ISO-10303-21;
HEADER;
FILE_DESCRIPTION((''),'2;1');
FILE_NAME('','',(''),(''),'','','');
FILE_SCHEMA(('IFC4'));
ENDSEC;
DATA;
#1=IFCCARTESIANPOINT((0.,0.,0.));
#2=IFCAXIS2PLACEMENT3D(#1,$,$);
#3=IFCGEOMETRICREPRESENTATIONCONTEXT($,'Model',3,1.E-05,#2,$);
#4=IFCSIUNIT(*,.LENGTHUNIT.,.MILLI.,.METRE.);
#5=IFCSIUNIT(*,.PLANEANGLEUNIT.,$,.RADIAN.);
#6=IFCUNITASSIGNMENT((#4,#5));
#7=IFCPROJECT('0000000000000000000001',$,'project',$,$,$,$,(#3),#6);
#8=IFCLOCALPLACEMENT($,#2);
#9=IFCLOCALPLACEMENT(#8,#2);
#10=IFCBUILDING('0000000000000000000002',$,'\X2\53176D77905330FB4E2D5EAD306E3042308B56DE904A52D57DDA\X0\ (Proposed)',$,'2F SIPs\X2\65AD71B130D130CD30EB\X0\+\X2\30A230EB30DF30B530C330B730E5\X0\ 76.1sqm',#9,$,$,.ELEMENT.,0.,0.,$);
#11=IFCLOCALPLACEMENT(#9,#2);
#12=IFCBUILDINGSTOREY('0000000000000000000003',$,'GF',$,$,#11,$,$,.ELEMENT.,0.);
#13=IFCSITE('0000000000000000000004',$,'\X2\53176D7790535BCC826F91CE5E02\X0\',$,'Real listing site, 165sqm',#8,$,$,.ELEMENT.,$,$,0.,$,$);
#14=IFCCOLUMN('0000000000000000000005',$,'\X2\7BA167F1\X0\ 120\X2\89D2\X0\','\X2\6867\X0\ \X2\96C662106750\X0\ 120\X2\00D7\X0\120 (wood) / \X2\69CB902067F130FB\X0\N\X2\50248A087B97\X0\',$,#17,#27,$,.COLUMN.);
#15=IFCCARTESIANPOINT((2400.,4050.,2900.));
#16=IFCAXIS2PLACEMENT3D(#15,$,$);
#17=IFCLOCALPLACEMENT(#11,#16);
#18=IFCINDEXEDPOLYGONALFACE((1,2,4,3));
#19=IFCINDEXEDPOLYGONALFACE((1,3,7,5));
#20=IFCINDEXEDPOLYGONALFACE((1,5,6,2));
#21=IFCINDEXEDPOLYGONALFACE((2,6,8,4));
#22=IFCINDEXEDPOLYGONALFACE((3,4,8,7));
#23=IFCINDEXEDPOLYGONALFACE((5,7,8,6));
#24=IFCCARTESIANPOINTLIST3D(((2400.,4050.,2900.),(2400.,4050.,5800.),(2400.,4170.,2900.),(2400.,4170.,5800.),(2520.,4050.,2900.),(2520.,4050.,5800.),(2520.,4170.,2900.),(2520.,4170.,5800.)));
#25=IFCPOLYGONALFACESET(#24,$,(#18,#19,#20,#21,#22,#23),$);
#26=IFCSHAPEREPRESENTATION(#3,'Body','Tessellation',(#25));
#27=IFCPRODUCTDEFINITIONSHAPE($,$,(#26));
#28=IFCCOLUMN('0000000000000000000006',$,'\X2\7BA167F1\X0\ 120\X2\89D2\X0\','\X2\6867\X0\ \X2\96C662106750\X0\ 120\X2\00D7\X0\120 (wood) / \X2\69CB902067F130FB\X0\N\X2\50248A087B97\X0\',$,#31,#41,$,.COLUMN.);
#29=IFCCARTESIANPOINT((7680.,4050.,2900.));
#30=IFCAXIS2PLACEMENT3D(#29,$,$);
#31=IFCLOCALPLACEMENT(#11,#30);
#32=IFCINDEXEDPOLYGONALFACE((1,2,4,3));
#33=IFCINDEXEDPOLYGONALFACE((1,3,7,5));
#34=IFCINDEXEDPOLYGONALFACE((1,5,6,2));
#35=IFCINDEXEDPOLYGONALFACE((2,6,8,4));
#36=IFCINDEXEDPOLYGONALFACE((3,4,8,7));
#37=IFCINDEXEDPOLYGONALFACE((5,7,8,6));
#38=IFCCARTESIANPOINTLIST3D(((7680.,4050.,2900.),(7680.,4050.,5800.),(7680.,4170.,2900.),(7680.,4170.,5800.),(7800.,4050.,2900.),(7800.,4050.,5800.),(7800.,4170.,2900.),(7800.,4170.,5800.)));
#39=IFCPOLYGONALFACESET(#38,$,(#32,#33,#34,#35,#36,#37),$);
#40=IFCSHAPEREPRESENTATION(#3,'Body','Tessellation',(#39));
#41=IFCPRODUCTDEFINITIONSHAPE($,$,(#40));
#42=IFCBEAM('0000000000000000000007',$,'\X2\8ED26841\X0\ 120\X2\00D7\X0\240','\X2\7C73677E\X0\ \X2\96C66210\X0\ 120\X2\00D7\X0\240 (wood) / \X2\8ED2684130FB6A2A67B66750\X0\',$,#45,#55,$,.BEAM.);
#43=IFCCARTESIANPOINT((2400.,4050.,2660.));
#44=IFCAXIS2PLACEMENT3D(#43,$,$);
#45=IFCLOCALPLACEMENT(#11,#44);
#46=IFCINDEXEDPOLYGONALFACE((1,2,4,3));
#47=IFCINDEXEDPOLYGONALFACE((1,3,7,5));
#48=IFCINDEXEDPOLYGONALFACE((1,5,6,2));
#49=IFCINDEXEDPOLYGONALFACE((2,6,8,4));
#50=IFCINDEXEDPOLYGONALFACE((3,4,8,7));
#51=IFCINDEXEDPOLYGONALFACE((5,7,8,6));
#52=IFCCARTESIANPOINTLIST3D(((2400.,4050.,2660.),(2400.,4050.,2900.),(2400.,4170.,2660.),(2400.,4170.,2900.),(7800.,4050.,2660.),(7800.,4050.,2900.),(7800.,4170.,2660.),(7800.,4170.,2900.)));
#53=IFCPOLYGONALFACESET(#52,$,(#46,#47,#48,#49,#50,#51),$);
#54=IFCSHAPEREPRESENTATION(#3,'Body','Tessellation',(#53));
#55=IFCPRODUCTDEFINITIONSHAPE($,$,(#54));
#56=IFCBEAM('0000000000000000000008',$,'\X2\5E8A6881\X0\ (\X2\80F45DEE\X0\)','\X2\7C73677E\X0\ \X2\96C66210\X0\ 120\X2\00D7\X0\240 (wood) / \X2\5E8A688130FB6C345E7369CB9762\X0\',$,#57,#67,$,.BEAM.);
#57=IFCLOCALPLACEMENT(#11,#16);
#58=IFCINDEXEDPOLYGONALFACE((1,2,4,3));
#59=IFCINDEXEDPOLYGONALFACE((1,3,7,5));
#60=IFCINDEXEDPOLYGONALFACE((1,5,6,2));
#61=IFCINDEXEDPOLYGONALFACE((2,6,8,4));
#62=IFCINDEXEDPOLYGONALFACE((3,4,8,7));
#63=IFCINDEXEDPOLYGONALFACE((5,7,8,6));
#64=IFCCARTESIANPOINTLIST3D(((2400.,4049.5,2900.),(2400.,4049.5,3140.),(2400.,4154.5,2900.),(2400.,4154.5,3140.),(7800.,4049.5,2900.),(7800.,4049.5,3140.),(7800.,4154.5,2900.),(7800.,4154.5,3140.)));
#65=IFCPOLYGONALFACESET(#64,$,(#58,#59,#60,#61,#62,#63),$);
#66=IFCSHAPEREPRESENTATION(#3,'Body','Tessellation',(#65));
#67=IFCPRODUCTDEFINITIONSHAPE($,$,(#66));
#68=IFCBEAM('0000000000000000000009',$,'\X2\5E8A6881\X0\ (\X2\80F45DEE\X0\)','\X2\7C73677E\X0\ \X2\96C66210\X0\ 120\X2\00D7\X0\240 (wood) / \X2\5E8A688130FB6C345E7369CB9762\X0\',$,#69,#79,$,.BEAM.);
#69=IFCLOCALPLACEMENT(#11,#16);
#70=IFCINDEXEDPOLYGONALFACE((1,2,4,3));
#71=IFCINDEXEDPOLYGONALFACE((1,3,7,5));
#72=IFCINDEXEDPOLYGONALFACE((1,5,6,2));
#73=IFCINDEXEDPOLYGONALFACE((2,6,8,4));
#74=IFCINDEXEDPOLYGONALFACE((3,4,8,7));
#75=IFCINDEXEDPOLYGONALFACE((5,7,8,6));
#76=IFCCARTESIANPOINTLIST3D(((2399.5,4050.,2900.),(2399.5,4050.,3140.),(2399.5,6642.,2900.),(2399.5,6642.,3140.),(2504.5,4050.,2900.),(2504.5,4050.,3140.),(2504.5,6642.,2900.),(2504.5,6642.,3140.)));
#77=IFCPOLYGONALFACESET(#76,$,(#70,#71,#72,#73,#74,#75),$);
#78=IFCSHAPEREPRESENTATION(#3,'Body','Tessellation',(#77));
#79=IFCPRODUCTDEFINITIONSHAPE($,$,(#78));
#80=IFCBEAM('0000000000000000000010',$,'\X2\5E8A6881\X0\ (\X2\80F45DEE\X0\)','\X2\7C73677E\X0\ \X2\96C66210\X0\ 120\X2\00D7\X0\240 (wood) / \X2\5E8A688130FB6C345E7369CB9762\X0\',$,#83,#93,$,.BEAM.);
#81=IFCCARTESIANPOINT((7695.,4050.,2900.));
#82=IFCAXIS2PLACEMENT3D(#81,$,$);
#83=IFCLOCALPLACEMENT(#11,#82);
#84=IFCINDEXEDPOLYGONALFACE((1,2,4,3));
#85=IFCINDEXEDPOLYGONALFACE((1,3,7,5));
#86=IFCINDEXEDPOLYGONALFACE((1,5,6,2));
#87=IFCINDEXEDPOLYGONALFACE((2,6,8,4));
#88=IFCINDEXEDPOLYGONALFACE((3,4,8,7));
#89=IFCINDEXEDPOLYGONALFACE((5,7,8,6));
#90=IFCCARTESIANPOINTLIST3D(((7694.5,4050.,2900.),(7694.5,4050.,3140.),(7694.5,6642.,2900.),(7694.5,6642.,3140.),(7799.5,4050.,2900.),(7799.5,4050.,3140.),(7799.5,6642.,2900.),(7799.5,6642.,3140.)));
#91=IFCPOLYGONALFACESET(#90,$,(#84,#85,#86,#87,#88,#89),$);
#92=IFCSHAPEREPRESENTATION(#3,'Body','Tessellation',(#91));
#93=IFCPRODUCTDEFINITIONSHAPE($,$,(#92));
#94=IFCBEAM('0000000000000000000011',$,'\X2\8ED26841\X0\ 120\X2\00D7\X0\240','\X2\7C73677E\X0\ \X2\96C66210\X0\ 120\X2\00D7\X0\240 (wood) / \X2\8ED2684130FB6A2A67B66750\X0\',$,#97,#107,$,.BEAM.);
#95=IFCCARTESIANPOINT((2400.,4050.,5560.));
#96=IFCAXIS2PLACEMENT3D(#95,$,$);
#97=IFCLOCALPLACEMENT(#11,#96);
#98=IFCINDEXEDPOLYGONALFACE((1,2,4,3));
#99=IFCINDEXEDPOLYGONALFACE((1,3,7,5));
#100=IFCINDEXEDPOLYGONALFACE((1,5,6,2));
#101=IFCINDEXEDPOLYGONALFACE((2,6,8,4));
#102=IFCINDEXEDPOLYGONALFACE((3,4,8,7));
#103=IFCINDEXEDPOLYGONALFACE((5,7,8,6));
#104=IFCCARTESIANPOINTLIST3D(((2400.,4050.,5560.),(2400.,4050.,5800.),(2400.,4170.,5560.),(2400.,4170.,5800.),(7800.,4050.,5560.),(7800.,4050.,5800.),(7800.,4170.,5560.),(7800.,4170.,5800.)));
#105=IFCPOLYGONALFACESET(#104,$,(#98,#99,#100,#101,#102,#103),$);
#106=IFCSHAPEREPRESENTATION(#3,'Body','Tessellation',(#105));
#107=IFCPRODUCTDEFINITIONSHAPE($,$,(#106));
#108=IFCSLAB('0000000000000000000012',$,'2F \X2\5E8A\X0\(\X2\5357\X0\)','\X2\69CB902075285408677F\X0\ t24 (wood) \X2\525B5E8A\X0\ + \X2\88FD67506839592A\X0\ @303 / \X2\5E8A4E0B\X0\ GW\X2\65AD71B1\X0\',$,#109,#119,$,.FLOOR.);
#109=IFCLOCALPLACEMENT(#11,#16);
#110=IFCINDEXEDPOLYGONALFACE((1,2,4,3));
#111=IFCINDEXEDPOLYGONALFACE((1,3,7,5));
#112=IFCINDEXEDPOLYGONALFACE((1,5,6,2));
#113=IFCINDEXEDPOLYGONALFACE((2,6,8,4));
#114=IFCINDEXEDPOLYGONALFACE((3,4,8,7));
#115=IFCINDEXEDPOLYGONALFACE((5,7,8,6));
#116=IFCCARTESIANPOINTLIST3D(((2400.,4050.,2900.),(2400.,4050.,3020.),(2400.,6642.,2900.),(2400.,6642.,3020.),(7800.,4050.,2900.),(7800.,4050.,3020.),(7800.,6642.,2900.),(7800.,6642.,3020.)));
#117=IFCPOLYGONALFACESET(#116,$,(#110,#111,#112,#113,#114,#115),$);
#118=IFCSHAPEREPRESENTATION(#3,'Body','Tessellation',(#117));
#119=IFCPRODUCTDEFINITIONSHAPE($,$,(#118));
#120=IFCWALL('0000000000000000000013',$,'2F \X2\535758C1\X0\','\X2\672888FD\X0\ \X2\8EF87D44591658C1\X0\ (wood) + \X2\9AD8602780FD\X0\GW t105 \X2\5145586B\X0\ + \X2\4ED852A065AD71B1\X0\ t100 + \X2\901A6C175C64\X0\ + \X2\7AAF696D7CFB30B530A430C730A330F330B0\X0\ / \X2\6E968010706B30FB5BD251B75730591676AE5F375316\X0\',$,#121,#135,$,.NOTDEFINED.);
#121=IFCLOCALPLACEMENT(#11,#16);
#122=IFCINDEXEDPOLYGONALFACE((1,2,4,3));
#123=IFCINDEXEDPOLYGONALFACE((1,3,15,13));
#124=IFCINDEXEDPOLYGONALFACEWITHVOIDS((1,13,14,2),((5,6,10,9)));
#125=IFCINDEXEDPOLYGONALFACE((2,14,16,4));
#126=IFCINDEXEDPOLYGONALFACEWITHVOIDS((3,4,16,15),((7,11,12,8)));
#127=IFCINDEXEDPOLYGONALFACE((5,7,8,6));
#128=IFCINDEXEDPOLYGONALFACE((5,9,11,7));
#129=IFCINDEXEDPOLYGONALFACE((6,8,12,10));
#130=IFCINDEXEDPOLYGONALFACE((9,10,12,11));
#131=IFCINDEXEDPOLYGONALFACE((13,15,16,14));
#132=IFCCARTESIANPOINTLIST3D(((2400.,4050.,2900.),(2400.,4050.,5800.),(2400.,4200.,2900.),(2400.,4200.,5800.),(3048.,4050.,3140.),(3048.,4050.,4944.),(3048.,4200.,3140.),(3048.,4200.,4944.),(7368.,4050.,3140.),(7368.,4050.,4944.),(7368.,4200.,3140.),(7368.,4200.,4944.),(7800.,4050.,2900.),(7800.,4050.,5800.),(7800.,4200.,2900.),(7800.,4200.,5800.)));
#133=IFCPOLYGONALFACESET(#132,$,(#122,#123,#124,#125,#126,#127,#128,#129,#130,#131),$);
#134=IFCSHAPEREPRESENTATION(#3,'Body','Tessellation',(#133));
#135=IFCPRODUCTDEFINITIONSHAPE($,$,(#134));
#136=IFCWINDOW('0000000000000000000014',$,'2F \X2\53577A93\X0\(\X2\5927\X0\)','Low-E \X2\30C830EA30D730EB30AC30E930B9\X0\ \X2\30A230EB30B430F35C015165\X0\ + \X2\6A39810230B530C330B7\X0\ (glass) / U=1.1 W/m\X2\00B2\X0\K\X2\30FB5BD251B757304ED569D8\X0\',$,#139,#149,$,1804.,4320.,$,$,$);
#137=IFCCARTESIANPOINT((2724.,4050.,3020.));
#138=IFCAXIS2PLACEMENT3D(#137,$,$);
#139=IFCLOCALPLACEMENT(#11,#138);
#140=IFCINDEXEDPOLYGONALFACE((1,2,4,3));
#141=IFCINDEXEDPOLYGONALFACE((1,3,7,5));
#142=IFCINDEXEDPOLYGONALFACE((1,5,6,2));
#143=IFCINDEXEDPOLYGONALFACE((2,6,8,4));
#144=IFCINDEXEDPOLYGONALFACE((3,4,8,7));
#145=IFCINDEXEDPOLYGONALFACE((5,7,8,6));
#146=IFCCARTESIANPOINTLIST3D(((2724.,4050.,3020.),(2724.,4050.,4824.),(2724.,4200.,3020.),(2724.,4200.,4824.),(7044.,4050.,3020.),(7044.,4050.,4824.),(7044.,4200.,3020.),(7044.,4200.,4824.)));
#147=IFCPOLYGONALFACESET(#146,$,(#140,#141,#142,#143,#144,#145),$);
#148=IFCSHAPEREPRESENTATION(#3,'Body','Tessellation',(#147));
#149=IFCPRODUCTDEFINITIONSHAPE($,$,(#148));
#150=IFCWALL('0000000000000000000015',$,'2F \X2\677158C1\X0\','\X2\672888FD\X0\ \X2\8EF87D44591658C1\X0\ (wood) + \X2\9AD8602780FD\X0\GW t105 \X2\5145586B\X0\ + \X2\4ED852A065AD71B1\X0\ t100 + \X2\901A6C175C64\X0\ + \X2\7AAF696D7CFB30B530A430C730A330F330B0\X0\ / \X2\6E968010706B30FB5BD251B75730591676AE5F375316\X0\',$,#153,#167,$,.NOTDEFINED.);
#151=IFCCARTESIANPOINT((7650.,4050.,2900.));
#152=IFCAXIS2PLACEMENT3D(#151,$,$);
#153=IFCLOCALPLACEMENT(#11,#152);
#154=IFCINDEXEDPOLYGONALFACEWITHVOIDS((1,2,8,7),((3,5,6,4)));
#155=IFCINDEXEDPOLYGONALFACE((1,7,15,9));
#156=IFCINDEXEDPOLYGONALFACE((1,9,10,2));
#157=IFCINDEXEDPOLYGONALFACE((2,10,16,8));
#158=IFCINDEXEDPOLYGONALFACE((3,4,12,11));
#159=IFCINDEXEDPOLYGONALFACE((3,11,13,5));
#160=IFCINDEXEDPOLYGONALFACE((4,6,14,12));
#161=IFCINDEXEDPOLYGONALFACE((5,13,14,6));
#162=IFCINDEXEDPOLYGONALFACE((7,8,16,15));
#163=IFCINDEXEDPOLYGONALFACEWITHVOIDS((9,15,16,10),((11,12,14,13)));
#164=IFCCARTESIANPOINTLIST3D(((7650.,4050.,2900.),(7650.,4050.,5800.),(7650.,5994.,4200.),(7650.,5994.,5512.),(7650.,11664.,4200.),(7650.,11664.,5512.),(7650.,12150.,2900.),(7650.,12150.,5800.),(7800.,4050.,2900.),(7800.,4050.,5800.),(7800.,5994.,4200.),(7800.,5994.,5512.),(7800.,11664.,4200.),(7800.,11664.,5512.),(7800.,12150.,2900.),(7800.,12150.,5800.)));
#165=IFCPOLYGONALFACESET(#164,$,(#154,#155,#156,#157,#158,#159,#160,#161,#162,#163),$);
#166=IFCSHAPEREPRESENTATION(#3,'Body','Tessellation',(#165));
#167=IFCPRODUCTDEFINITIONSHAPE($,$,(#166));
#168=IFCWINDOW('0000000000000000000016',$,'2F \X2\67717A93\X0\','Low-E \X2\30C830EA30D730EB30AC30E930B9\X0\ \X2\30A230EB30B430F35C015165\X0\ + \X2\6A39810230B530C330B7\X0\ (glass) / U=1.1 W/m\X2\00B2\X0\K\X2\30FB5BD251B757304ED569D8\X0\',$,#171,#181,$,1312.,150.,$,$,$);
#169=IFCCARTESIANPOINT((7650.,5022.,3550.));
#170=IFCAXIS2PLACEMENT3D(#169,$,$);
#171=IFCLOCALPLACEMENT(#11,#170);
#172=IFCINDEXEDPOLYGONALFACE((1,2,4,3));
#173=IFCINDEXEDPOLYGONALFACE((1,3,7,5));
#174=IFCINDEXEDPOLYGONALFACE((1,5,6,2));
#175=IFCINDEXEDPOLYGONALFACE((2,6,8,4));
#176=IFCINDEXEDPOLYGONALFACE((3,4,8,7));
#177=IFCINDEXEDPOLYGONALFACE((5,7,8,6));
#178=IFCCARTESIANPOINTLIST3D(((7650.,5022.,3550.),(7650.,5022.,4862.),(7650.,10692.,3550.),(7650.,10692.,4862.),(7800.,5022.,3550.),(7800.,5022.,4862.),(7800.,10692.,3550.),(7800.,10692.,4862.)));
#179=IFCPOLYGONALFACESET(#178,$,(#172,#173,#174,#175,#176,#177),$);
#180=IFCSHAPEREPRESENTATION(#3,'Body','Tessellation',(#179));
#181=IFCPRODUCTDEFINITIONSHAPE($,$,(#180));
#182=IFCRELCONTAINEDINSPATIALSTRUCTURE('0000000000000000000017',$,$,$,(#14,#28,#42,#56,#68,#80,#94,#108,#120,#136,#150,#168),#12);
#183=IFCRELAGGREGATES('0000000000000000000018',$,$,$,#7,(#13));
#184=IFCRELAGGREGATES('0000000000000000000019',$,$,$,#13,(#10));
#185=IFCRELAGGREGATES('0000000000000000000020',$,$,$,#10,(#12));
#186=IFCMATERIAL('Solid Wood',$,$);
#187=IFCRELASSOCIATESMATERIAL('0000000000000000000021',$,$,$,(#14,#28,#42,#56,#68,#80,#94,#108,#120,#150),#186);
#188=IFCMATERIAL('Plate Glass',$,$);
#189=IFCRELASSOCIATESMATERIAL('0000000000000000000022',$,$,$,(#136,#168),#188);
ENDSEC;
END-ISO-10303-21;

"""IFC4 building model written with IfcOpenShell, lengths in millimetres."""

from ifc_helpers import new_model, si_unit, frame, frame_2d, origin, place, context, project, spatial, rectangle, extrude, material, element, fill, save


model = new_model("IFC4")

# Units and contexts
model_context = context("Model", 3, precision=1e-05, world=origin())
ifc_project = project(units=[si_unit("LENGTHUNIT", "METRE", prefix="MILLI"), si_unit("PLANEANGLEUNIT", "RADIAN")], contexts=[model_context])

# Site, building, storey
site_placement = place(None, origin())
site = spatial("IfcSite", under=ifc_project, at=site_placement, Name="北海道富良野市", ObjectType="Real listing site, 165sqm", CompositionType="ELEMENT", RefElevation=0.0)
building_placement = place(site_placement, origin())
building = spatial("IfcBuilding", under=site, at=building_placement, Name="北海道・中庭のある回遊動線 (Proposed)", ObjectType="2F SIPs断熱パネル+アルミサッシュ 76.1sqm", CompositionType="ELEMENT", ElevationOfRefHeight=0.0, ElevationOfTerrain=0.0)
storey_placement = place(building_placement, origin())
storey = spatial("IfcBuildingStorey", under=building, at=storey_placement, Name="GF", CompositionType="ELEMENT", Elevation=0.0)

# Columns
ifc_material_1 = material(Name="Solid Wood")
column_1_placement = place(storey_placement, frame((2400.0, 4050.0, 2900.0)))
element("IfcColumn", 1, at=column_1_placement, inside=storey, material=ifc_material_1, Name="管柱 120角", Description="桧 集成材 120×120 (wood) / 構造柱・N値計算", PredefinedType="COLUMN", context=model_context, shape_type="SweptSolid", body=[
    extrude(rectangle(XDim=120.0, YDim=120.0, at=frame_2d((60.0, 60.0))), frame((2400.0, 4050.0, 2900.0)), (0.0, 0.0, 1.0), 2900.0),
])
column_2_placement = place(storey_placement, frame((7680.0, 4050.0, 2900.0)))
element("IfcColumn", 2, at=column_2_placement, inside=storey, material=ifc_material_1, Name="管柱 120角", Description="桧 集成材 120×120 (wood) / 構造柱・N値計算", PredefinedType="COLUMN", context=model_context, shape_type="SweptSolid", body=[
    extrude(rectangle(XDim=120.0, YDim=120.0, at=frame_2d((60.0, 60.0))), frame((7680.0, 4050.0, 2900.0)), (0.0, 0.0, 1.0), 2900.0),
])

# Beams
beam_1_placement = place(storey_placement, frame((2400.0, 4050.0, 2660.0)))
element("IfcBeam", 3, at=beam_1_placement, inside=storey, material=ifc_material_1, Name="軒桁 120×240", Description="米松 集成 120×240 (wood) / 軒桁・横架材", PredefinedType="BEAM", context=model_context, shape_type="SweptSolid", body=[
    extrude(rectangle(XDim=5400.0, YDim=120.0, at=frame_2d((2700.0, 60.0))), frame((2400.0, 4050.0, 2660.0)), (0.0, 0.0, 1.0), 240.0),
])
beam_2_placement = place(storey_placement, frame((2400.0, 4050.0, 2900.0)))
element("IfcBeam", 4, at=beam_2_placement, inside=storey, material=ifc_material_1, Name="床梁 (胴差)", Description="米松 集成 120×240 (wood) / 床梁・水平構面", PredefinedType="BEAM", context=model_context, shape_type="SweptSolid", body=[
    extrude(rectangle(XDim=5400.0, YDim=105.0, at=frame_2d((2700.0, 52.0))), frame((2400.0, 4050.0, 2900.0)), (0.0, 0.0, 1.0), 240.0),
])
beam_3_placement = place(storey_placement, frame((2400.0, 4050.0, 2900.0)))
element("IfcBeam", 5, at=beam_3_placement, inside=storey, material=ifc_material_1, Name="床梁 (胴差)", Description="米松 集成 120×240 (wood) / 床梁・水平構面", PredefinedType="BEAM", context=model_context, shape_type="SweptSolid", body=[
    extrude(rectangle(XDim=105.0, YDim=2592.0, at=frame_2d((52.0, 1296.0))), frame((2400.0, 4050.0, 2900.0)), (0.0, 0.0, 1.0), 240.0),
])
beam_4_placement = place(storey_placement, frame((7695.0, 4050.0, 2900.0)))
element("IfcBeam", 6, at=beam_4_placement, inside=storey, material=ifc_material_1, Name="床梁 (胴差)", Description="米松 集成 120×240 (wood) / 床梁・水平構面", PredefinedType="BEAM", context=model_context, shape_type="SweptSolid", body=[
    extrude(rectangle(XDim=105.0, YDim=2592.0, at=frame_2d((52.0, 1296.0))), frame((7695.0, 4050.0, 2900.0)), (0.0, 0.0, 1.0), 240.0),
])
beam_5_placement = place(storey_placement, frame((2400.0, 4050.0, 5560.0)))
element("IfcBeam", 7, at=beam_5_placement, inside=storey, material=ifc_material_1, Name="軒桁 120×240", Description="米松 集成 120×240 (wood) / 軒桁・横架材", PredefinedType="BEAM", context=model_context, shape_type="SweptSolid", body=[
    extrude(rectangle(XDim=5400.0, YDim=120.0, at=frame_2d((2700.0, 60.0))), frame((2400.0, 4050.0, 5560.0)), (0.0, 0.0, 1.0), 240.0),
])

# Slab
slab_placement = place(storey_placement, frame((2400.0, 4050.0, 2900.0)))
element("IfcSlab", 8, at=slab_placement, inside=storey, material=ifc_material_1, Name="2F 床(南)", Description="構造用合板 t24 (wood) 剛床 + 製材根太 @303 / 床下 GW断熱", PredefinedType="FLOOR", context=model_context, shape_type="SweptSolid", body=[
    extrude(rectangle(XDim=5400.0, YDim=2592.0, at=frame_2d((2700.0, 1296.0))), frame((2400.0, 4050.0, 2900.0)), (0.0, 0.0, 1.0), 120.0),
])

# Walls, openings, windows
wall_1_placement = place(storey_placement, frame((2400.0, 4050.0, 2900.0)))
wall_1 = element("IfcWall", 9, at=wall_1_placement, inside=storey, material=ifc_material_1, Name="2F 南壁", Description="木製 軸組外壁 (wood) + 高性能GW t105 充填 + 付加断熱 t100 + 通気層 + 窯業系サイディング / 準耐火・寒冷地外皮強化", PredefinedType="NOTDEFINED", context=model_context, shape_type="SweptSolid", body=[
    extrude(rectangle(XDim=5400.0, YDim=150.0, at=frame_2d((2700.0, 75.0))), frame((2400.0, 4050.0, 2900.0)), (0.0, 0.0, 1.0), 2900.0),
])
opening_1_placement = place(storey_placement, frame((2724.0, 4050.0, 3020.0)))
opening_1 = element("IfcOpeningElement", 10, at=opening_1_placement, cuts=wall_1, PredefinedType="NOTDEFINED", context=model_context, shape_type="SweptSolid", body=[
    extrude(rectangle(XDim=4320.0, YDim=150.0, at=frame_2d((2160.0, 75.0))), frame((2724.0, 4050.0, 3020.0)), (0.0, 0.0, 1.0), 1804.0),
])
ifc_material_2 = material(Name="Plate Glass")
window_1_placement = place(storey_placement, frame((2724.0, 4050.0, 3020.0)))
window_1 = element("IfcWindow", 11, at=window_1_placement, inside=storey, material=ifc_material_2, Name="2F 南窓(大)", Description="Low-E トリプルガラス アルゴン封入 + 樹脂サッシ (glass) / U=1.1 W/m²K・寒冷地仕様", OverallHeight=1804.0, OverallWidth=4320.0, context=model_context, shape_type="SweptSolid", body=[
    extrude(rectangle(XDim=4320.0, YDim=150.0, at=frame_2d((2160.0, 75.0))), frame((2724.0, 4050.0, 3020.0)), (0.0, 0.0, 1.0), 1804.0),
])
fill(opening_1, window_1)
wall_2_placement = place(storey_placement, frame((7650.0, 4050.0, 2900.0)))
wall_2 = element("IfcWall", 12, at=wall_2_placement, inside=storey, material=ifc_material_1, Name="2F 東壁", Description="木製 軸組外壁 (wood) + 高性能GW t105 充填 + 付加断熱 t100 + 通気層 + 窯業系サイディング / 準耐火・寒冷地外皮強化", PredefinedType="NOTDEFINED", context=model_context, shape_type="SweptSolid", body=[
    extrude(rectangle(XDim=150.0, YDim=8100.0, at=frame_2d((75.0, 4050.0))), frame((7650.0, 4050.0, 2900.0)), (0.0, 0.0, 1.0), 2900.0),
])
opening_2_placement = place(storey_placement, frame((7650.0, 5022.0, 3550.0)))
opening_2 = element("IfcOpeningElement", 13, at=opening_2_placement, cuts=wall_2, PredefinedType="NOTDEFINED", context=model_context, shape_type="SweptSolid", body=[
    extrude(rectangle(XDim=150.0, YDim=5670.0, at=frame_2d((75.0, 2835.0))), frame((7650.0, 5022.0, 3550.0)), (0.0, 0.0, 1.0), 1312.0),
])
window_2_placement = place(storey_placement, frame((7650.0, 5022.0, 3550.0)))
window_2 = element("IfcWindow", 14, at=window_2_placement, inside=storey, material=ifc_material_2, Name="2F 東窓", Description="Low-E トリプルガラス アルゴン封入 + 樹脂サッシ (glass) / U=1.1 W/m²K・寒冷地仕様", OverallHeight=1312.0, OverallWidth=150.0, context=model_context, shape_type="SweptSolid", body=[
    extrude(rectangle(XDim=150.0, YDim=5670.0, at=frame_2d((75.0, 2835.0))), frame((7650.0, 5022.0, 3550.0)), (0.0, 0.0, 1.0), 1312.0),
])
fill(opening_2, window_2)

save(model, "model.ifc")
